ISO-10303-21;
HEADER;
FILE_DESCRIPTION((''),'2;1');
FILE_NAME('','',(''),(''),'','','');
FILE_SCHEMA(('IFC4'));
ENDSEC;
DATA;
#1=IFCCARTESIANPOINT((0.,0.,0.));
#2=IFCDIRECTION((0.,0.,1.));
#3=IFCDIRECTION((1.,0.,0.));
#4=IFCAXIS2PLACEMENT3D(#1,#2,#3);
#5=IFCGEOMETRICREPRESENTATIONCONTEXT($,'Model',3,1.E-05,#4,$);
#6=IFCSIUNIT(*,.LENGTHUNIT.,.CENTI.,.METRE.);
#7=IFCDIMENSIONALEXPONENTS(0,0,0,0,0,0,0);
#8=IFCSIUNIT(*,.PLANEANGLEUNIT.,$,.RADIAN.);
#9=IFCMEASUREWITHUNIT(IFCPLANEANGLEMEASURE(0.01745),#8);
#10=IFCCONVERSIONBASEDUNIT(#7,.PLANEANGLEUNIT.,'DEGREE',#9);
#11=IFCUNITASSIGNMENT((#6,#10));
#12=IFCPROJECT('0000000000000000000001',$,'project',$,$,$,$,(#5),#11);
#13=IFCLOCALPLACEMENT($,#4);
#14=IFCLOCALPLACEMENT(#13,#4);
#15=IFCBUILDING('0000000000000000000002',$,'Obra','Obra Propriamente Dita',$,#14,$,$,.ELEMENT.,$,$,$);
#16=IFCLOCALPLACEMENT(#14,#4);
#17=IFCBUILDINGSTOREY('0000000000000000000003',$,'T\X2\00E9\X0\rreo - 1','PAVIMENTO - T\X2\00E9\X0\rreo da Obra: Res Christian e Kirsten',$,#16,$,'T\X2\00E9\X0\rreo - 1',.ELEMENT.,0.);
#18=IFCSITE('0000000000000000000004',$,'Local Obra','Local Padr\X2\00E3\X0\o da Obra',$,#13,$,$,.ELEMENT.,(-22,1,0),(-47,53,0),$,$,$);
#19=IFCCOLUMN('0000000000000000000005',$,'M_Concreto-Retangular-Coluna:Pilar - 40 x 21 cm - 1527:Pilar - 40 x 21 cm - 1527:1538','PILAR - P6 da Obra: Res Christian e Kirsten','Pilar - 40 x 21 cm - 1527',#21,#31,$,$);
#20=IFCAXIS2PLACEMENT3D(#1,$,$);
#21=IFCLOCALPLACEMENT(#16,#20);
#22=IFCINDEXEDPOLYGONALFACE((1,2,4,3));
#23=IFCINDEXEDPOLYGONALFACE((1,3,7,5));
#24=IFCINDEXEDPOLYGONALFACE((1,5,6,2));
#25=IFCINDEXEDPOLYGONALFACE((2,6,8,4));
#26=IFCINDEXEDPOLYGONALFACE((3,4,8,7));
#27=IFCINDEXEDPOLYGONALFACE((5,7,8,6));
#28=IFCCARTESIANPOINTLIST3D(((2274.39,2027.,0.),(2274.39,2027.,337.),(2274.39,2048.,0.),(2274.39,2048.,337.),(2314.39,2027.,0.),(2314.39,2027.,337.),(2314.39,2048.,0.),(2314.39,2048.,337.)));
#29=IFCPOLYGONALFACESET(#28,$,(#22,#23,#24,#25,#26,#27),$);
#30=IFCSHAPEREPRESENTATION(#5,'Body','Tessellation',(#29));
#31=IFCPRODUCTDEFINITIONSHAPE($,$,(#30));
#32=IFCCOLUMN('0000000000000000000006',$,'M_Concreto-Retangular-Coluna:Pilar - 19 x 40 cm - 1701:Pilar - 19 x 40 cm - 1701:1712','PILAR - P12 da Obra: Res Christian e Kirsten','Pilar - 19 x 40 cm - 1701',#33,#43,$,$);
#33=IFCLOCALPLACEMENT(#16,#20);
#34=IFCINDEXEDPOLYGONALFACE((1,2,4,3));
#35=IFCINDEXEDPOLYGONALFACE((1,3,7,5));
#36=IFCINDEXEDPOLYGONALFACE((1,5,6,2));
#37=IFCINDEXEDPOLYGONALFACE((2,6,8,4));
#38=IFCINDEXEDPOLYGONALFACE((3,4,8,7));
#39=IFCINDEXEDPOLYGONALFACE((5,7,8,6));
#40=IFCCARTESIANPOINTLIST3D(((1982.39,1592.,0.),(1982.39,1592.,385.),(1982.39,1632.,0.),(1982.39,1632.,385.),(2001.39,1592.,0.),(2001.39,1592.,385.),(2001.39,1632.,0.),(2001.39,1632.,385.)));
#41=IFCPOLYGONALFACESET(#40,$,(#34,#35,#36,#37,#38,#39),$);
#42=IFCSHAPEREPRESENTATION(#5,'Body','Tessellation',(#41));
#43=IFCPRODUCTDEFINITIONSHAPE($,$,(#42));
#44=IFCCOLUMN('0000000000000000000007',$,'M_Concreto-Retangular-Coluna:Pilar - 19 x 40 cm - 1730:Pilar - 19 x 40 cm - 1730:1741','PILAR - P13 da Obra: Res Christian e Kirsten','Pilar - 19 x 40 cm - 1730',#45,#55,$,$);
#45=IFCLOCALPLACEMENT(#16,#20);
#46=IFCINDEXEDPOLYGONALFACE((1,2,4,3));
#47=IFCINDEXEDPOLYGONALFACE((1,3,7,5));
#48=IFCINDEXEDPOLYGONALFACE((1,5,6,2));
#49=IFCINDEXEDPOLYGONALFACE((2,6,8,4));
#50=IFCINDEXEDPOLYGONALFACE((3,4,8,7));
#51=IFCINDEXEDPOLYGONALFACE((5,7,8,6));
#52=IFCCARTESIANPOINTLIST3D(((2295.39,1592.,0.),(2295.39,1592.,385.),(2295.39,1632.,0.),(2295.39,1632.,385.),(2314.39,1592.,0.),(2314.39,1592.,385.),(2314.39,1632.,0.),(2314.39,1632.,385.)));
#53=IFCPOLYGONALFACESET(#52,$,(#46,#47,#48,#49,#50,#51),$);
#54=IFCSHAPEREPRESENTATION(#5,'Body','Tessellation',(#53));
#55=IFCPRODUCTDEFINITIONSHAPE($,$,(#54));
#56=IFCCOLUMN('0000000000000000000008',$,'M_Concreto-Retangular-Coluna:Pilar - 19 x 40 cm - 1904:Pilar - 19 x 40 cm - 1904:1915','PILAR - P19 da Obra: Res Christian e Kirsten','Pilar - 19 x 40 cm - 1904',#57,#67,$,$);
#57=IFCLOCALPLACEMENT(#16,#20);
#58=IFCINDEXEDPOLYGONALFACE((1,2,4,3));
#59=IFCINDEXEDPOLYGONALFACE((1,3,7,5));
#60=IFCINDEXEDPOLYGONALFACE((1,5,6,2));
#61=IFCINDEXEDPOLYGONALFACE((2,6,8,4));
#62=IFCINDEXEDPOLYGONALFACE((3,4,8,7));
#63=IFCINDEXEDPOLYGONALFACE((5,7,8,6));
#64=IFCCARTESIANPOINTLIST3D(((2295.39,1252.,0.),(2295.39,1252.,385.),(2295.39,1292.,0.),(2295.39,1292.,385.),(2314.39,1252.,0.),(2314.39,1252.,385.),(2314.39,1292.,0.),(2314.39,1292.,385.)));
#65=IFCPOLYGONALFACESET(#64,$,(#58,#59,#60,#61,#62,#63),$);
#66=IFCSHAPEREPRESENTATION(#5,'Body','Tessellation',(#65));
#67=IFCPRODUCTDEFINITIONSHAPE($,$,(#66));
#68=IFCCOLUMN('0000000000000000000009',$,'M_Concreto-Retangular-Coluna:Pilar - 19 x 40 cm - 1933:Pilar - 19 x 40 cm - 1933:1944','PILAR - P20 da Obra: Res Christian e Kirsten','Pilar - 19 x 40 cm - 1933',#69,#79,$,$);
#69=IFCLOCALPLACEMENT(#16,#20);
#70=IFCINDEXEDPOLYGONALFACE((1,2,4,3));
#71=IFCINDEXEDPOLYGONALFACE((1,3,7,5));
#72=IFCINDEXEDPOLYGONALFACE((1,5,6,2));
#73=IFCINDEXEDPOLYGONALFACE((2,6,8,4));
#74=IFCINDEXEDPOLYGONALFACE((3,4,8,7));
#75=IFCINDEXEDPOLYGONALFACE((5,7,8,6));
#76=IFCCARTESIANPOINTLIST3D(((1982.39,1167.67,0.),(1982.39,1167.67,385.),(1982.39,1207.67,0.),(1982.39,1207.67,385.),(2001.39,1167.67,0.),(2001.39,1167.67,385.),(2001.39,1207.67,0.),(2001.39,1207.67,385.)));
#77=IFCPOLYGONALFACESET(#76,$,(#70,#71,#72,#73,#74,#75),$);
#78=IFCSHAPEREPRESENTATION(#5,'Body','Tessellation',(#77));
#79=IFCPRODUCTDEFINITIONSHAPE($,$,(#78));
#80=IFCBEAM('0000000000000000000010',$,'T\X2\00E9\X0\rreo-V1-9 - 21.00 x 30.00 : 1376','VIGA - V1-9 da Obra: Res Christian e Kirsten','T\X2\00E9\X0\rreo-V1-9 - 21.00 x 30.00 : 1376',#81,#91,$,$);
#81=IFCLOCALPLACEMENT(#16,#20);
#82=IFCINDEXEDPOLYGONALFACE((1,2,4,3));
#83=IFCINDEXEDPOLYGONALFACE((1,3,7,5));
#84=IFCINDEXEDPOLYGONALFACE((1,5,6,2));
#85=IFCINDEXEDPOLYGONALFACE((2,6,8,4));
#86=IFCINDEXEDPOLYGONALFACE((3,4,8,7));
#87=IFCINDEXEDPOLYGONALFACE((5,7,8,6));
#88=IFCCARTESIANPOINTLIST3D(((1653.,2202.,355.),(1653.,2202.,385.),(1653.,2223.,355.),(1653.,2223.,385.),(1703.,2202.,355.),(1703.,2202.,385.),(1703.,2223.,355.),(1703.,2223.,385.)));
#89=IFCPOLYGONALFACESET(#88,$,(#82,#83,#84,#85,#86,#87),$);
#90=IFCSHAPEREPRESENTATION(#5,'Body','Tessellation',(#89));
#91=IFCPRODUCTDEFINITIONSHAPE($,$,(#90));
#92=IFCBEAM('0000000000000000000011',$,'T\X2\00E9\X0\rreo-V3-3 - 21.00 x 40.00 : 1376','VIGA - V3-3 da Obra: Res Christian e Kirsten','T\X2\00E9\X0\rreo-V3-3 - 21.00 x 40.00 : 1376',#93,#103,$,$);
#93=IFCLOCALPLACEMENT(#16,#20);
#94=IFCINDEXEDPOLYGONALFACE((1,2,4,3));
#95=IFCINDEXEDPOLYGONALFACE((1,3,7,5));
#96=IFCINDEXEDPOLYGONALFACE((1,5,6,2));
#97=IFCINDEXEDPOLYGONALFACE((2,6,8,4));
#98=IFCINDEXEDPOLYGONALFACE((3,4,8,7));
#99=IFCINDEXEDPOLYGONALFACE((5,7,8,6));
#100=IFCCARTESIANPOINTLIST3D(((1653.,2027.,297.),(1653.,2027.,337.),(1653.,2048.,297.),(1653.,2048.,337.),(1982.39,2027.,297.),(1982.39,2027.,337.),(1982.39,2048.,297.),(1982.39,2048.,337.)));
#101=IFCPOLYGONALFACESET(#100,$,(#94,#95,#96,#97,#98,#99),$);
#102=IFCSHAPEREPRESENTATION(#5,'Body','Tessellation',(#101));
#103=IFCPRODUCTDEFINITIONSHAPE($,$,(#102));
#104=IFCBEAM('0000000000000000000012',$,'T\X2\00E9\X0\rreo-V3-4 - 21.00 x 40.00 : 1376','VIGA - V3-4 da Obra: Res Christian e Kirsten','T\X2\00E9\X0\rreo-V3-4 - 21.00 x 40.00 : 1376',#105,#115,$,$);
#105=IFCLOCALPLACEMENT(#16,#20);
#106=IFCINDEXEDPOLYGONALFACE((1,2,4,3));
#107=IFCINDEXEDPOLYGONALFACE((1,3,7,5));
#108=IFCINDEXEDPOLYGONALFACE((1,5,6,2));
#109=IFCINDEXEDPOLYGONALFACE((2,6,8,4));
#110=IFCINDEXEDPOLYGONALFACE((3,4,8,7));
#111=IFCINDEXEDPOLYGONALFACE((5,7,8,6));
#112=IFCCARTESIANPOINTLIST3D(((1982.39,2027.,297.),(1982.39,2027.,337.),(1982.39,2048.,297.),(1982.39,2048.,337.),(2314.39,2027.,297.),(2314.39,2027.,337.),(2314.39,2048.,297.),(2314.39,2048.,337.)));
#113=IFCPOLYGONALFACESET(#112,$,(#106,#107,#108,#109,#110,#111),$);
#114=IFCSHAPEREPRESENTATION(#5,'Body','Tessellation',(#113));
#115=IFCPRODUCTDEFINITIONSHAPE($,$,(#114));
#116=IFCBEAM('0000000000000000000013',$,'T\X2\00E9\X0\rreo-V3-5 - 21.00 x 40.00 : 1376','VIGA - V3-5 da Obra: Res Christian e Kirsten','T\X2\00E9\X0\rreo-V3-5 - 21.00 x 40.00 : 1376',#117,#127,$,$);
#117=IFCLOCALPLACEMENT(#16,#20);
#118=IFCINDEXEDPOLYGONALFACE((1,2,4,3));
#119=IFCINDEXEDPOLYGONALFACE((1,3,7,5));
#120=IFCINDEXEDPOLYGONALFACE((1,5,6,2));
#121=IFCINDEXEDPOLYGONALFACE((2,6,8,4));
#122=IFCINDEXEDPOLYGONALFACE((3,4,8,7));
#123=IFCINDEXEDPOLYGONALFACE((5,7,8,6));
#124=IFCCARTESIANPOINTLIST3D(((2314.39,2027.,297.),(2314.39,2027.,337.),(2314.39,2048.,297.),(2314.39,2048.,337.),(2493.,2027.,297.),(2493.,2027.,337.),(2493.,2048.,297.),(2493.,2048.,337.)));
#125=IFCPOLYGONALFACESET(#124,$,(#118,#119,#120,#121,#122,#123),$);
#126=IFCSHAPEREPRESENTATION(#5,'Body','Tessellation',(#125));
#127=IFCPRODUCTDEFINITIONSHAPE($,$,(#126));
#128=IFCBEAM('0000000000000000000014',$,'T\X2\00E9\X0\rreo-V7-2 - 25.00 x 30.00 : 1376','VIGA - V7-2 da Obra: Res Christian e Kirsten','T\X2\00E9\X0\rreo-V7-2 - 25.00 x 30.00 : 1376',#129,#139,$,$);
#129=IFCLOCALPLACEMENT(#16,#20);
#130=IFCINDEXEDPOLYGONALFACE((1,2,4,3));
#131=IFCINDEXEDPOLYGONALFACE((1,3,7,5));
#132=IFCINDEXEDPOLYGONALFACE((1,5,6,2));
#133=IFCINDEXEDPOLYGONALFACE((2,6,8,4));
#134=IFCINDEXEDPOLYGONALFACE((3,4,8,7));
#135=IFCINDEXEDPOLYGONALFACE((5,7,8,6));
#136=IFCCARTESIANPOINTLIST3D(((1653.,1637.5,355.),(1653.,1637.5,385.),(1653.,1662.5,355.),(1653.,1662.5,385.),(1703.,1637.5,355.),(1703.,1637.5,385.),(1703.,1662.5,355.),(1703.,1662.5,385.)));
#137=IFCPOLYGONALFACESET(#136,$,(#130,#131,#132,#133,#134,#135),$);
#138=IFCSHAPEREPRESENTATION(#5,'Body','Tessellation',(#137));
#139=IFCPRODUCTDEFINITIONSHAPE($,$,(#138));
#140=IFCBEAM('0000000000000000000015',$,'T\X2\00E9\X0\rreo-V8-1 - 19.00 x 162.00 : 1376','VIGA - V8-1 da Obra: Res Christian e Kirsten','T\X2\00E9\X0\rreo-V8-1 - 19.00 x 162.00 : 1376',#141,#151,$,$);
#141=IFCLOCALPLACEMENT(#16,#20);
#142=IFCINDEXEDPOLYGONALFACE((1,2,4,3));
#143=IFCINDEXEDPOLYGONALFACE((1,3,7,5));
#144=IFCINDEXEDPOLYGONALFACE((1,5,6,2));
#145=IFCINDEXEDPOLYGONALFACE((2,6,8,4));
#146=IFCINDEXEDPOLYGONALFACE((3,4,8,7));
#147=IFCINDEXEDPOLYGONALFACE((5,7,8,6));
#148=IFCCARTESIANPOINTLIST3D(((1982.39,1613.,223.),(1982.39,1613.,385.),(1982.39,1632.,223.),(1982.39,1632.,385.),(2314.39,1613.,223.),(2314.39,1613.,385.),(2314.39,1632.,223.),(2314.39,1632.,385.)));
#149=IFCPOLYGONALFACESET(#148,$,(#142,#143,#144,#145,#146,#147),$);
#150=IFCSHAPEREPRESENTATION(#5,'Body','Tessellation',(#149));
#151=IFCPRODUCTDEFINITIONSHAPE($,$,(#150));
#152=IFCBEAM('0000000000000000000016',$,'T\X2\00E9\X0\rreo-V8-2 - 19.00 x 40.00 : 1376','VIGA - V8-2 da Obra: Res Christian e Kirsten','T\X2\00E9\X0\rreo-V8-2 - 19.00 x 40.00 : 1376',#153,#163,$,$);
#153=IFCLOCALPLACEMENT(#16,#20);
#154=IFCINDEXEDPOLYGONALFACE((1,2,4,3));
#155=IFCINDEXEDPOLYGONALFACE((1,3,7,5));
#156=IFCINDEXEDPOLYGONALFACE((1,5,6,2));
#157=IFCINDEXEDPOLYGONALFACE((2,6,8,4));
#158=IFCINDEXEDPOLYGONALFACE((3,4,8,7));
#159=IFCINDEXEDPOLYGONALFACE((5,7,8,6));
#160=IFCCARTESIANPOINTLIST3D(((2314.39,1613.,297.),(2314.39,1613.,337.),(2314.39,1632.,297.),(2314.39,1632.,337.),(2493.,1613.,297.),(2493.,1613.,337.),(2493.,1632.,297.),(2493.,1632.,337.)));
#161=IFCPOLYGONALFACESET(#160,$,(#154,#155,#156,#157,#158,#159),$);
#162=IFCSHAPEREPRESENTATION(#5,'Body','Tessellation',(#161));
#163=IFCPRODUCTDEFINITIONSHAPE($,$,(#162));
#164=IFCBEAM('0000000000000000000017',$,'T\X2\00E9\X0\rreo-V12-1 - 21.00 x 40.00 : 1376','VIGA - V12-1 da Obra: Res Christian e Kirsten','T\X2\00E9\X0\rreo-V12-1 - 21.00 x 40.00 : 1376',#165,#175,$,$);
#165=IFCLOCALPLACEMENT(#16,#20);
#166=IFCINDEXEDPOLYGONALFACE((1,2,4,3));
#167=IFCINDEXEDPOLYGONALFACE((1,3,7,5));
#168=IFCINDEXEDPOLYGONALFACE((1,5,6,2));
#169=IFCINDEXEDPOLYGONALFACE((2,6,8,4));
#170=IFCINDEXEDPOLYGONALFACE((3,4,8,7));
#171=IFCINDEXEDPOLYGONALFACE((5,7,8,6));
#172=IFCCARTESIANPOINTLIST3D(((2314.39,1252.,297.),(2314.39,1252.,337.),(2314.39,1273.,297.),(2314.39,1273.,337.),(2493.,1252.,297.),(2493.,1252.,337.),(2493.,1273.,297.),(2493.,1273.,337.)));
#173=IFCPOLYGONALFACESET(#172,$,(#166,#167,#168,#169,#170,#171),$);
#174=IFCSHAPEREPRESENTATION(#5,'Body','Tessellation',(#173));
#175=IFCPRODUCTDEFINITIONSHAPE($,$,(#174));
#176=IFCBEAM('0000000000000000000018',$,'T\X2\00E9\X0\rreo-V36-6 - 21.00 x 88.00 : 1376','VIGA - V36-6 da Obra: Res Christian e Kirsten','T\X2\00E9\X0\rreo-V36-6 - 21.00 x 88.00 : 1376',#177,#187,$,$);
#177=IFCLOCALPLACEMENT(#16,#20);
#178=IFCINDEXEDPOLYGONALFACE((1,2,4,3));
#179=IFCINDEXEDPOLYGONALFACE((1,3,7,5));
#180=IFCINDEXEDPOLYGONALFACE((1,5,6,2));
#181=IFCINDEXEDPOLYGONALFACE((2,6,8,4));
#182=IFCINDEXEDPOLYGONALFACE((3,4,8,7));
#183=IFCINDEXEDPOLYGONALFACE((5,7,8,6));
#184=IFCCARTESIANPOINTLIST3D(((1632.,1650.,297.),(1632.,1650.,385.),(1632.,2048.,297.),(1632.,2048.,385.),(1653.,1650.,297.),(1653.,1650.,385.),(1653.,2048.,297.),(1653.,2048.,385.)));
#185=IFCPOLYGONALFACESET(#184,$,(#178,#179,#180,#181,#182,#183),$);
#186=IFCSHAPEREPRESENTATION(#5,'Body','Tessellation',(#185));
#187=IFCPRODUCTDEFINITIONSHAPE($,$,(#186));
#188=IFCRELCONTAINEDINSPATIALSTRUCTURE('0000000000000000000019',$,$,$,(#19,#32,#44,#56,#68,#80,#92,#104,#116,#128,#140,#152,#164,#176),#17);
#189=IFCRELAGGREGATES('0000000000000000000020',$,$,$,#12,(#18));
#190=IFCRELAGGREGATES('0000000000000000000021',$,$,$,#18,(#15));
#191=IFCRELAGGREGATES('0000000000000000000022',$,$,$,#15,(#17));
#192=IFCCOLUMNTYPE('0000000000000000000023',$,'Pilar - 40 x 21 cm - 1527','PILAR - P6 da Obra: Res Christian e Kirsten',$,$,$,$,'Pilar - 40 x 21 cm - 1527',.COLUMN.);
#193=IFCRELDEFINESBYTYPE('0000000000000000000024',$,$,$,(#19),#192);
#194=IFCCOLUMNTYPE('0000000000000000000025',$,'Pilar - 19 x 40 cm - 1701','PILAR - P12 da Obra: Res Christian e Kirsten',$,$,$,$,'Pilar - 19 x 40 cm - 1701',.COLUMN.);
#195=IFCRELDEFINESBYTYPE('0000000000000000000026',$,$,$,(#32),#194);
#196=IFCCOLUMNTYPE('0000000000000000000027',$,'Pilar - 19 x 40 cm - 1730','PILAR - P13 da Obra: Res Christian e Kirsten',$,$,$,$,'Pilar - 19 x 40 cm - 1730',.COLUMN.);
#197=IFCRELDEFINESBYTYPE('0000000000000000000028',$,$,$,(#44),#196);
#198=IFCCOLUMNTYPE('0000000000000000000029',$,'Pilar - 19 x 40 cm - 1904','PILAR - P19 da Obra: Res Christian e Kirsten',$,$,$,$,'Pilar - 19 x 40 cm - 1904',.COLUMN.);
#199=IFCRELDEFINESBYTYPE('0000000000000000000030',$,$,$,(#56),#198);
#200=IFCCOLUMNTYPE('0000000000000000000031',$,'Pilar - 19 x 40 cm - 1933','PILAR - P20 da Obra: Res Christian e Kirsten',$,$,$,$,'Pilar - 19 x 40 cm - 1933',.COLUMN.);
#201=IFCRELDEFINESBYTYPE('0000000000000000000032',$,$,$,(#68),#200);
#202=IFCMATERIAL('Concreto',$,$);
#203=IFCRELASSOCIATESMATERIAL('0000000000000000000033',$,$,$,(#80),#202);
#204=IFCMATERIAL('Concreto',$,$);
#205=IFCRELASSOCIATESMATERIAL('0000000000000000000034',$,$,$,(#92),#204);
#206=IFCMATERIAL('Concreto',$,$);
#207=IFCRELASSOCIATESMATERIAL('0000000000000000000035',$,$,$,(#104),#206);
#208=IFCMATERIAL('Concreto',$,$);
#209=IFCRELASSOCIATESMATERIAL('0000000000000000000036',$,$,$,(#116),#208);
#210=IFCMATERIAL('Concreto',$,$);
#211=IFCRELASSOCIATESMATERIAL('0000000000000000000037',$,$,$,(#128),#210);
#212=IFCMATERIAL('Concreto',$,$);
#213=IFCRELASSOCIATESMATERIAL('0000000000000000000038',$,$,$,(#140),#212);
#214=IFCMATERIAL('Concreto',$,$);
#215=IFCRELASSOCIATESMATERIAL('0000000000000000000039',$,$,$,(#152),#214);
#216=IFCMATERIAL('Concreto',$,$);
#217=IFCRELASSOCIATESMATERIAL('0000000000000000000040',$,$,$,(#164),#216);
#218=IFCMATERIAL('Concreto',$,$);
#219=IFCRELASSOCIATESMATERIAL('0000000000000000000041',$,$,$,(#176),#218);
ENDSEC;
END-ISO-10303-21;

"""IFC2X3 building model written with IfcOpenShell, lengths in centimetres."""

from ifc_helpers import new_model, entity, si_unit, converted_unit, frame, origin, origin_with_axes, origin_2d_with_axis, place, context, project, spatial, polyline, rectangle, outline, extrude, source, transform, mapped, material, type_object, type_shapes, element, save


model = new_model("IFC2X3")

# Units and contexts
model_context = context("Model", 3, precision=1e-05, world=origin_with_axes())
ifc_project = project(units=[si_unit("LENGTHUNIT", "METRE", prefix="CENTI"), converted_unit("PLANEANGLEUNIT", "DEGREE", entity("IfcPlaneAngleMeasure", 0.01745), si_unit("PLANEANGLEUNIT", "RADIAN"), dimensions=[0, 0, 0, 0, 0, 0, 0])], contexts=[model_context])

# Site, building, storey
site_placement = place(None, origin_with_axes())
site = spatial("IfcSite", under=ifc_project, at=site_placement, Name="Local Obra", Description="Local Padrão da Obra", CompositionType="ELEMENT", RefLatitude=(-22, 1, 0), RefLongitude=(-47, 53, 0))
building_placement = place(site_placement, origin_with_axes())
building = spatial("IfcBuilding", under=site, at=building_placement, Name="Obra", Description="Obra Propriamente Dita", CompositionType="ELEMENT")
storey_placement = place(building_placement, origin_with_axes())
storey = spatial("IfcBuildingStorey", under=building, at=storey_placement, Name="Térreo - 1", Description="PAVIMENTO - Térreo da Obra: Res Christian e Kirsten", LongName="Térreo - 1", CompositionType="ELEMENT", Elevation=0.0)

# Columns
column_type_1 = type_object("IfcColumnType", Name="Pilar - 40 x 21 cm - 1527", Description="PILAR - P6 da Obra: Res Christian e Kirsten", ElementType="Pilar - 40 x 21 cm - 1527", PredefinedType="COLUMN")
shared_shape_1 = source(origin(), model_context, "Body", "SweptSolid", [
    extrude(rectangle(XDim=40.0, YDim=21.0, at=origin_2d_with_axis()), origin(), (0.0, 0.0, 1.0), 337.0),
])
type_shapes(column_type_1, [shared_shape_1])
column_1_placement = place(storey_placement, frame((2294.39, 2037.5, 0.0), z_axis=(0.0, 0.0, 1.0), x_axis=(1.0, 0.0, 0.0)))
element("IfcColumn", 1, at=column_1_placement, inside=storey, type_object=column_type_1, Name="M_Concreto-Retangular-Coluna:Pilar - 40 x 21 cm - 1527:Pilar - 40 x 21 cm - 1527:1538", Description="PILAR - P6 da Obra: Res Christian e Kirsten", ObjectType="Pilar - 40 x 21 cm - 1527", context=model_context, shape_type="MappedRepresentation", body=[
    mapped(shared_shape_1, transform((0.0, 0.0, 0.0), scale=1.0)),
])
column_type_2 = type_object("IfcColumnType", Name="Pilar - 19 x 40 cm - 1701", Description="PILAR - P12 da Obra: Res Christian e Kirsten", ElementType="Pilar - 19 x 40 cm - 1701", PredefinedType="COLUMN")
shared_shape_2 = source(origin(), model_context, "Body", "SweptSolid", [
    extrude(rectangle(XDim=19.0, YDim=40.0, at=origin_2d_with_axis()), origin(), (0.0, 0.0, 1.0), 385.0),
])
type_shapes(column_type_2, [shared_shape_2])
column_2_placement = place(storey_placement, frame((1991.89, 1612.0, 0.0), z_axis=(0.0, 0.0, 1.0), x_axis=(1.0, 0.0, 0.0)))
element("IfcColumn", 2, at=column_2_placement, inside=storey, type_object=column_type_2, Name="M_Concreto-Retangular-Coluna:Pilar - 19 x 40 cm - 1701:Pilar - 19 x 40 cm - 1701:1712", Description="PILAR - P12 da Obra: Res Christian e Kirsten", ObjectType="Pilar - 19 x 40 cm - 1701", context=model_context, shape_type="MappedRepresentation", body=[
    mapped(shared_shape_2, transform((0.0, 0.0, 0.0), scale=1.0)),
])
column_type_3 = type_object("IfcColumnType", Name="Pilar - 19 x 40 cm - 1730", Description="PILAR - P13 da Obra: Res Christian e Kirsten", ElementType="Pilar - 19 x 40 cm - 1730", PredefinedType="COLUMN")
shared_shape_3 = source(origin(), model_context, "Body", "SweptSolid", [
    extrude(rectangle(XDim=19.0, YDim=40.0, at=origin_2d_with_axis()), origin(), (0.0, 0.0, 1.0), 385.0),
])
type_shapes(column_type_3, [shared_shape_3])
column_3_placement = place(storey_placement, frame((2304.89, 1612.0, 0.0), z_axis=(0.0, 0.0, 1.0), x_axis=(1.0, 0.0, 0.0)))
element("IfcColumn", 3, at=column_3_placement, inside=storey, type_object=column_type_3, Name="M_Concreto-Retangular-Coluna:Pilar - 19 x 40 cm - 1730:Pilar - 19 x 40 cm - 1730:1741", Description="PILAR - P13 da Obra: Res Christian e Kirsten", ObjectType="Pilar - 19 x 40 cm - 1730", context=model_context, shape_type="MappedRepresentation", body=[
    mapped(shared_shape_3, transform((0.0, 0.0, 0.0), scale=1.0)),
])
column_type_4 = type_object("IfcColumnType", Name="Pilar - 19 x 40 cm - 1904", Description="PILAR - P19 da Obra: Res Christian e Kirsten", ElementType="Pilar - 19 x 40 cm - 1904", PredefinedType="COLUMN")
shared_shape_4 = source(origin(), model_context, "Body", "SweptSolid", [
    extrude(rectangle(XDim=19.0, YDim=40.0, at=origin_2d_with_axis()), origin(), (0.0, 0.0, 1.0), 385.0),
])
type_shapes(column_type_4, [shared_shape_4])
column_4_placement = place(storey_placement, frame((2304.89, 1272.0, 0.0), z_axis=(0.0, 0.0, 1.0), x_axis=(1.0, 0.0, 0.0)))
element("IfcColumn", 4, at=column_4_placement, inside=storey, type_object=column_type_4, Name="M_Concreto-Retangular-Coluna:Pilar - 19 x 40 cm - 1904:Pilar - 19 x 40 cm - 1904:1915", Description="PILAR - P19 da Obra: Res Christian e Kirsten", ObjectType="Pilar - 19 x 40 cm - 1904", context=model_context, shape_type="MappedRepresentation", body=[
    mapped(shared_shape_4, transform((0.0, 0.0, 0.0), scale=1.0)),
])
column_type_5 = type_object("IfcColumnType", Name="Pilar - 19 x 40 cm - 1933", Description="PILAR - P20 da Obra: Res Christian e Kirsten", ElementType="Pilar - 19 x 40 cm - 1933", PredefinedType="COLUMN")
shared_shape_5 = source(origin(), model_context, "Body", "SweptSolid", [
    extrude(rectangle(XDim=19.0, YDim=40.0, at=origin_2d_with_axis()), origin(), (0.0, 0.0, 1.0), 385.0),
])
type_shapes(column_type_5, [shared_shape_5])
column_5_placement = place(storey_placement, frame((1991.89, 1187.67, 0.0), z_axis=(0.0, 0.0, 1.0), x_axis=(1.0, 0.0, 0.0)))
element("IfcColumn", 5, at=column_5_placement, inside=storey, type_object=column_type_5, Name="M_Concreto-Retangular-Coluna:Pilar - 19 x 40 cm - 1933:Pilar - 19 x 40 cm - 1933:1944", Description="PILAR - P20 da Obra: Res Christian e Kirsten", ObjectType="Pilar - 19 x 40 cm - 1933", context=model_context, shape_type="MappedRepresentation", body=[
    mapped(shared_shape_5, transform((0.0, 0.0, 0.0), scale=1.0)),
])

# Beams
ifc_material_1 = material(Name="Concreto")
beam_1_placement = place(storey_placement, frame((1653.0, 2223.0, 385.0), z_axis=(1.0, 0.0, 0.0), x_axis=(0.0, -1.0, 0.0)))
element("IfcBeam", 6, at=beam_1_placement, inside=storey, material=ifc_material_1, Name="Térreo-V1-9 - 21.00 x 30.00 : 1376", Description="VIGA - V1-9 da Obra: Res Christian e Kirsten", ObjectType="Térreo-V1-9 - 21.00 x 30.00 : 1376", context=model_context, shape_type="SweptSolid", body=[
    extrude(outline(polyline([(0.0, 0.0), (21.0, 0.0), (21.0, 30.0), (0.0, 30.0), (0.0, 0.0)])), origin_with_axes(), (0.0, 0.0, 1.0), 50.0),
])
ifc_material_2 = material(Name="Concreto")
beam_2_placement = place(storey_placement, frame((1653.0, 2048.0, 337.0), z_axis=(1.0, 0.0, 0.0), x_axis=(0.0, -1.0, 0.0)))
element("IfcBeam", 7, at=beam_2_placement, inside=storey, material=ifc_material_2, Name="Térreo-V3-3 - 21.00 x 40.00 : 1376", Description="VIGA - V3-3 da Obra: Res Christian e Kirsten", ObjectType="Térreo-V3-3 - 21.00 x 40.00 : 1376", context=model_context, shape_type="SweptSolid", body=[
    extrude(outline(polyline([(0.0, 0.0), (21.0, 0.0), (21.0, 40.0), (0.0, 40.0), (0.0, 0.0)])), origin_with_axes(), (0.0, 0.0, 1.0), 329.39),
])
ifc_material_3 = material(Name="Concreto")
beam_3_placement = place(storey_placement, frame((1982.39, 2048.0, 337.0), z_axis=(1.0, 0.0, 0.0), x_axis=(0.0, -1.0, 0.0)))
element("IfcBeam", 8, at=beam_3_placement, inside=storey, material=ifc_material_3, Name="Térreo-V3-4 - 21.00 x 40.00 : 1376", Description="VIGA - V3-4 da Obra: Res Christian e Kirsten", ObjectType="Térreo-V3-4 - 21.00 x 40.00 : 1376", context=model_context, shape_type="SweptSolid", body=[
    extrude(outline(polyline([(0.0, 0.0), (21.0, 0.0), (21.0, 40.0), (0.0, 40.0), (0.0, 0.0)])), origin_with_axes(), (0.0, 0.0, 1.0), 332.0),
])
ifc_material_4 = material(Name="Concreto")
beam_4_placement = place(storey_placement, frame((2314.39, 2048.0, 337.0), z_axis=(1.0, 0.0, 0.0), x_axis=(0.0, -1.0, 0.0)))
element("IfcBeam", 9, at=beam_4_placement, inside=storey, material=ifc_material_4, Name="Térreo-V3-5 - 21.00 x 40.00 : 1376", Description="VIGA - V3-5 da Obra: Res Christian e Kirsten", ObjectType="Térreo-V3-5 - 21.00 x 40.00 : 1376", context=model_context, shape_type="SweptSolid", body=[
    extrude(outline(polyline([(0.0, 0.0), (21.0, 0.0), (21.0, 40.0), (0.0, 40.0), (0.0, 0.0)])), origin_with_axes(), (0.0, 0.0, 1.0), 178.6),
])
ifc_material_5 = material(Name="Concreto")
beam_5_placement = place(storey_placement, frame((1653.0, 1650.0, 385.0), z_axis=(1.0, 0.0, 0.0), x_axis=(0.0, -1.0, 0.0)))
element("IfcBeam", 10, at=beam_5_placement, inside=storey, material=ifc_material_5, Name="Térreo-V7-2 - 25.00 x 30.00 : 1376", Description="VIGA - V7-2 da Obra: Res Christian e Kirsten", ObjectType="Térreo-V7-2 - 25.00 x 30.00 : 1376", context=model_context, shape_type="SweptSolid", body=[
    extrude(outline(polyline([(-12.5, 0.0), (12.5, 0.0), (12.5, 30.0), (-12.5, 30.0), (-12.5, 0.0)])), origin_with_axes(), (0.0, 0.0, 1.0), 50.0),
])
ifc_material_6 = material(Name="Concreto")
beam_6_placement = place(storey_placement, frame((1982.39, 1632.0, 385.0), z_axis=(1.0, 0.0, 0.0), x_axis=(0.0, -1.0, 0.0)))
element("IfcBeam", 11, at=beam_6_placement, inside=storey, material=ifc_material_6, Name="Térreo-V8-1 - 19.00 x 162.00 : 1376", Description="VIGA - V8-1 da Obra: Res Christian e Kirsten", ObjectType="Térreo-V8-1 - 19.00 x 162.00 : 1376", context=model_context, shape_type="SweptSolid", body=[
    extrude(outline(polyline([(0.0, 0.0), (19.0, 0.0), (19.0, 162.0), (0.0, 162.0), (0.0, 0.0)])), origin_with_axes(), (0.0, 0.0, 1.0), 332.0),
])
ifc_material_7 = material(Name="Concreto")
beam_7_placement = place(storey_placement, frame((2314.39, 1632.0, 337.0), z_axis=(1.0, 0.0, 0.0), x_axis=(0.0, -1.0, 0.0)))
element("IfcBeam", 12, at=beam_7_placement, inside=storey, material=ifc_material_7, Name="Térreo-V8-2 - 19.00 x 40.00 : 1376", Description="VIGA - V8-2 da Obra: Res Christian e Kirsten", ObjectType="Térreo-V8-2 - 19.00 x 40.00 : 1376", context=model_context, shape_type="SweptSolid", body=[
    extrude(outline(polyline([(0.0, 0.0), (19.0, 0.0), (19.0, 40.0), (0.0, 40.0), (0.0, 0.0)])), origin_with_axes(), (0.0, 0.0, 1.0), 178.6),
])
ifc_material_8 = material(Name="Concreto")
beam_8_placement = place(storey_placement, frame((2314.39, 1252.0, 337.0), z_axis=(1.0, 0.0, 0.0), x_axis=(0.0, -1.0, 0.0)))
element("IfcBeam", 13, at=beam_8_placement, inside=storey, material=ifc_material_8, Name="Térreo-V12-1 - 21.00 x 40.00 : 1376", Description="VIGA - V12-1 da Obra: Res Christian e Kirsten", ObjectType="Térreo-V12-1 - 21.00 x 40.00 : 1376", context=model_context, shape_type="SweptSolid", body=[
    extrude(outline(polyline([(-21.0, 0.0), (0.0, 0.0), (0.0, 40.0), (-21.0, 40.0), (-21.0, 0.0)])), origin_with_axes(), (0.0, 0.0, 1.0), 178.6),
])
ifc_material_9 = material(Name="Concreto")
beam_9_placement = place(storey_placement, frame((1653.0, 1650.0, 385.0), z_axis=(0.0, 1.0, 0.0), x_axis=(1.0, 0.0, 0.0)))
element("IfcBeam", 14, at=beam_9_placement, inside=storey, material=ifc_material_9, Name="Térreo-V36-6 - 21.00 x 88.00 : 1376", Description="VIGA - V36-6 da Obra: Res Christian e Kirsten", ObjectType="Térreo-V36-6 - 21.00 x 88.00 : 1376", context=model_context, shape_type="SweptSolid", body=[
    extrude(outline(polyline([(-21.0, 0.0), (0.0, 0.0), (0.0, 88.0), (-21.0, 88.0), (-21.0, 0.0)])), origin_with_axes(), (0.0, 0.0, 1.0), 398.0),
])

save(model, "model.ifc")
